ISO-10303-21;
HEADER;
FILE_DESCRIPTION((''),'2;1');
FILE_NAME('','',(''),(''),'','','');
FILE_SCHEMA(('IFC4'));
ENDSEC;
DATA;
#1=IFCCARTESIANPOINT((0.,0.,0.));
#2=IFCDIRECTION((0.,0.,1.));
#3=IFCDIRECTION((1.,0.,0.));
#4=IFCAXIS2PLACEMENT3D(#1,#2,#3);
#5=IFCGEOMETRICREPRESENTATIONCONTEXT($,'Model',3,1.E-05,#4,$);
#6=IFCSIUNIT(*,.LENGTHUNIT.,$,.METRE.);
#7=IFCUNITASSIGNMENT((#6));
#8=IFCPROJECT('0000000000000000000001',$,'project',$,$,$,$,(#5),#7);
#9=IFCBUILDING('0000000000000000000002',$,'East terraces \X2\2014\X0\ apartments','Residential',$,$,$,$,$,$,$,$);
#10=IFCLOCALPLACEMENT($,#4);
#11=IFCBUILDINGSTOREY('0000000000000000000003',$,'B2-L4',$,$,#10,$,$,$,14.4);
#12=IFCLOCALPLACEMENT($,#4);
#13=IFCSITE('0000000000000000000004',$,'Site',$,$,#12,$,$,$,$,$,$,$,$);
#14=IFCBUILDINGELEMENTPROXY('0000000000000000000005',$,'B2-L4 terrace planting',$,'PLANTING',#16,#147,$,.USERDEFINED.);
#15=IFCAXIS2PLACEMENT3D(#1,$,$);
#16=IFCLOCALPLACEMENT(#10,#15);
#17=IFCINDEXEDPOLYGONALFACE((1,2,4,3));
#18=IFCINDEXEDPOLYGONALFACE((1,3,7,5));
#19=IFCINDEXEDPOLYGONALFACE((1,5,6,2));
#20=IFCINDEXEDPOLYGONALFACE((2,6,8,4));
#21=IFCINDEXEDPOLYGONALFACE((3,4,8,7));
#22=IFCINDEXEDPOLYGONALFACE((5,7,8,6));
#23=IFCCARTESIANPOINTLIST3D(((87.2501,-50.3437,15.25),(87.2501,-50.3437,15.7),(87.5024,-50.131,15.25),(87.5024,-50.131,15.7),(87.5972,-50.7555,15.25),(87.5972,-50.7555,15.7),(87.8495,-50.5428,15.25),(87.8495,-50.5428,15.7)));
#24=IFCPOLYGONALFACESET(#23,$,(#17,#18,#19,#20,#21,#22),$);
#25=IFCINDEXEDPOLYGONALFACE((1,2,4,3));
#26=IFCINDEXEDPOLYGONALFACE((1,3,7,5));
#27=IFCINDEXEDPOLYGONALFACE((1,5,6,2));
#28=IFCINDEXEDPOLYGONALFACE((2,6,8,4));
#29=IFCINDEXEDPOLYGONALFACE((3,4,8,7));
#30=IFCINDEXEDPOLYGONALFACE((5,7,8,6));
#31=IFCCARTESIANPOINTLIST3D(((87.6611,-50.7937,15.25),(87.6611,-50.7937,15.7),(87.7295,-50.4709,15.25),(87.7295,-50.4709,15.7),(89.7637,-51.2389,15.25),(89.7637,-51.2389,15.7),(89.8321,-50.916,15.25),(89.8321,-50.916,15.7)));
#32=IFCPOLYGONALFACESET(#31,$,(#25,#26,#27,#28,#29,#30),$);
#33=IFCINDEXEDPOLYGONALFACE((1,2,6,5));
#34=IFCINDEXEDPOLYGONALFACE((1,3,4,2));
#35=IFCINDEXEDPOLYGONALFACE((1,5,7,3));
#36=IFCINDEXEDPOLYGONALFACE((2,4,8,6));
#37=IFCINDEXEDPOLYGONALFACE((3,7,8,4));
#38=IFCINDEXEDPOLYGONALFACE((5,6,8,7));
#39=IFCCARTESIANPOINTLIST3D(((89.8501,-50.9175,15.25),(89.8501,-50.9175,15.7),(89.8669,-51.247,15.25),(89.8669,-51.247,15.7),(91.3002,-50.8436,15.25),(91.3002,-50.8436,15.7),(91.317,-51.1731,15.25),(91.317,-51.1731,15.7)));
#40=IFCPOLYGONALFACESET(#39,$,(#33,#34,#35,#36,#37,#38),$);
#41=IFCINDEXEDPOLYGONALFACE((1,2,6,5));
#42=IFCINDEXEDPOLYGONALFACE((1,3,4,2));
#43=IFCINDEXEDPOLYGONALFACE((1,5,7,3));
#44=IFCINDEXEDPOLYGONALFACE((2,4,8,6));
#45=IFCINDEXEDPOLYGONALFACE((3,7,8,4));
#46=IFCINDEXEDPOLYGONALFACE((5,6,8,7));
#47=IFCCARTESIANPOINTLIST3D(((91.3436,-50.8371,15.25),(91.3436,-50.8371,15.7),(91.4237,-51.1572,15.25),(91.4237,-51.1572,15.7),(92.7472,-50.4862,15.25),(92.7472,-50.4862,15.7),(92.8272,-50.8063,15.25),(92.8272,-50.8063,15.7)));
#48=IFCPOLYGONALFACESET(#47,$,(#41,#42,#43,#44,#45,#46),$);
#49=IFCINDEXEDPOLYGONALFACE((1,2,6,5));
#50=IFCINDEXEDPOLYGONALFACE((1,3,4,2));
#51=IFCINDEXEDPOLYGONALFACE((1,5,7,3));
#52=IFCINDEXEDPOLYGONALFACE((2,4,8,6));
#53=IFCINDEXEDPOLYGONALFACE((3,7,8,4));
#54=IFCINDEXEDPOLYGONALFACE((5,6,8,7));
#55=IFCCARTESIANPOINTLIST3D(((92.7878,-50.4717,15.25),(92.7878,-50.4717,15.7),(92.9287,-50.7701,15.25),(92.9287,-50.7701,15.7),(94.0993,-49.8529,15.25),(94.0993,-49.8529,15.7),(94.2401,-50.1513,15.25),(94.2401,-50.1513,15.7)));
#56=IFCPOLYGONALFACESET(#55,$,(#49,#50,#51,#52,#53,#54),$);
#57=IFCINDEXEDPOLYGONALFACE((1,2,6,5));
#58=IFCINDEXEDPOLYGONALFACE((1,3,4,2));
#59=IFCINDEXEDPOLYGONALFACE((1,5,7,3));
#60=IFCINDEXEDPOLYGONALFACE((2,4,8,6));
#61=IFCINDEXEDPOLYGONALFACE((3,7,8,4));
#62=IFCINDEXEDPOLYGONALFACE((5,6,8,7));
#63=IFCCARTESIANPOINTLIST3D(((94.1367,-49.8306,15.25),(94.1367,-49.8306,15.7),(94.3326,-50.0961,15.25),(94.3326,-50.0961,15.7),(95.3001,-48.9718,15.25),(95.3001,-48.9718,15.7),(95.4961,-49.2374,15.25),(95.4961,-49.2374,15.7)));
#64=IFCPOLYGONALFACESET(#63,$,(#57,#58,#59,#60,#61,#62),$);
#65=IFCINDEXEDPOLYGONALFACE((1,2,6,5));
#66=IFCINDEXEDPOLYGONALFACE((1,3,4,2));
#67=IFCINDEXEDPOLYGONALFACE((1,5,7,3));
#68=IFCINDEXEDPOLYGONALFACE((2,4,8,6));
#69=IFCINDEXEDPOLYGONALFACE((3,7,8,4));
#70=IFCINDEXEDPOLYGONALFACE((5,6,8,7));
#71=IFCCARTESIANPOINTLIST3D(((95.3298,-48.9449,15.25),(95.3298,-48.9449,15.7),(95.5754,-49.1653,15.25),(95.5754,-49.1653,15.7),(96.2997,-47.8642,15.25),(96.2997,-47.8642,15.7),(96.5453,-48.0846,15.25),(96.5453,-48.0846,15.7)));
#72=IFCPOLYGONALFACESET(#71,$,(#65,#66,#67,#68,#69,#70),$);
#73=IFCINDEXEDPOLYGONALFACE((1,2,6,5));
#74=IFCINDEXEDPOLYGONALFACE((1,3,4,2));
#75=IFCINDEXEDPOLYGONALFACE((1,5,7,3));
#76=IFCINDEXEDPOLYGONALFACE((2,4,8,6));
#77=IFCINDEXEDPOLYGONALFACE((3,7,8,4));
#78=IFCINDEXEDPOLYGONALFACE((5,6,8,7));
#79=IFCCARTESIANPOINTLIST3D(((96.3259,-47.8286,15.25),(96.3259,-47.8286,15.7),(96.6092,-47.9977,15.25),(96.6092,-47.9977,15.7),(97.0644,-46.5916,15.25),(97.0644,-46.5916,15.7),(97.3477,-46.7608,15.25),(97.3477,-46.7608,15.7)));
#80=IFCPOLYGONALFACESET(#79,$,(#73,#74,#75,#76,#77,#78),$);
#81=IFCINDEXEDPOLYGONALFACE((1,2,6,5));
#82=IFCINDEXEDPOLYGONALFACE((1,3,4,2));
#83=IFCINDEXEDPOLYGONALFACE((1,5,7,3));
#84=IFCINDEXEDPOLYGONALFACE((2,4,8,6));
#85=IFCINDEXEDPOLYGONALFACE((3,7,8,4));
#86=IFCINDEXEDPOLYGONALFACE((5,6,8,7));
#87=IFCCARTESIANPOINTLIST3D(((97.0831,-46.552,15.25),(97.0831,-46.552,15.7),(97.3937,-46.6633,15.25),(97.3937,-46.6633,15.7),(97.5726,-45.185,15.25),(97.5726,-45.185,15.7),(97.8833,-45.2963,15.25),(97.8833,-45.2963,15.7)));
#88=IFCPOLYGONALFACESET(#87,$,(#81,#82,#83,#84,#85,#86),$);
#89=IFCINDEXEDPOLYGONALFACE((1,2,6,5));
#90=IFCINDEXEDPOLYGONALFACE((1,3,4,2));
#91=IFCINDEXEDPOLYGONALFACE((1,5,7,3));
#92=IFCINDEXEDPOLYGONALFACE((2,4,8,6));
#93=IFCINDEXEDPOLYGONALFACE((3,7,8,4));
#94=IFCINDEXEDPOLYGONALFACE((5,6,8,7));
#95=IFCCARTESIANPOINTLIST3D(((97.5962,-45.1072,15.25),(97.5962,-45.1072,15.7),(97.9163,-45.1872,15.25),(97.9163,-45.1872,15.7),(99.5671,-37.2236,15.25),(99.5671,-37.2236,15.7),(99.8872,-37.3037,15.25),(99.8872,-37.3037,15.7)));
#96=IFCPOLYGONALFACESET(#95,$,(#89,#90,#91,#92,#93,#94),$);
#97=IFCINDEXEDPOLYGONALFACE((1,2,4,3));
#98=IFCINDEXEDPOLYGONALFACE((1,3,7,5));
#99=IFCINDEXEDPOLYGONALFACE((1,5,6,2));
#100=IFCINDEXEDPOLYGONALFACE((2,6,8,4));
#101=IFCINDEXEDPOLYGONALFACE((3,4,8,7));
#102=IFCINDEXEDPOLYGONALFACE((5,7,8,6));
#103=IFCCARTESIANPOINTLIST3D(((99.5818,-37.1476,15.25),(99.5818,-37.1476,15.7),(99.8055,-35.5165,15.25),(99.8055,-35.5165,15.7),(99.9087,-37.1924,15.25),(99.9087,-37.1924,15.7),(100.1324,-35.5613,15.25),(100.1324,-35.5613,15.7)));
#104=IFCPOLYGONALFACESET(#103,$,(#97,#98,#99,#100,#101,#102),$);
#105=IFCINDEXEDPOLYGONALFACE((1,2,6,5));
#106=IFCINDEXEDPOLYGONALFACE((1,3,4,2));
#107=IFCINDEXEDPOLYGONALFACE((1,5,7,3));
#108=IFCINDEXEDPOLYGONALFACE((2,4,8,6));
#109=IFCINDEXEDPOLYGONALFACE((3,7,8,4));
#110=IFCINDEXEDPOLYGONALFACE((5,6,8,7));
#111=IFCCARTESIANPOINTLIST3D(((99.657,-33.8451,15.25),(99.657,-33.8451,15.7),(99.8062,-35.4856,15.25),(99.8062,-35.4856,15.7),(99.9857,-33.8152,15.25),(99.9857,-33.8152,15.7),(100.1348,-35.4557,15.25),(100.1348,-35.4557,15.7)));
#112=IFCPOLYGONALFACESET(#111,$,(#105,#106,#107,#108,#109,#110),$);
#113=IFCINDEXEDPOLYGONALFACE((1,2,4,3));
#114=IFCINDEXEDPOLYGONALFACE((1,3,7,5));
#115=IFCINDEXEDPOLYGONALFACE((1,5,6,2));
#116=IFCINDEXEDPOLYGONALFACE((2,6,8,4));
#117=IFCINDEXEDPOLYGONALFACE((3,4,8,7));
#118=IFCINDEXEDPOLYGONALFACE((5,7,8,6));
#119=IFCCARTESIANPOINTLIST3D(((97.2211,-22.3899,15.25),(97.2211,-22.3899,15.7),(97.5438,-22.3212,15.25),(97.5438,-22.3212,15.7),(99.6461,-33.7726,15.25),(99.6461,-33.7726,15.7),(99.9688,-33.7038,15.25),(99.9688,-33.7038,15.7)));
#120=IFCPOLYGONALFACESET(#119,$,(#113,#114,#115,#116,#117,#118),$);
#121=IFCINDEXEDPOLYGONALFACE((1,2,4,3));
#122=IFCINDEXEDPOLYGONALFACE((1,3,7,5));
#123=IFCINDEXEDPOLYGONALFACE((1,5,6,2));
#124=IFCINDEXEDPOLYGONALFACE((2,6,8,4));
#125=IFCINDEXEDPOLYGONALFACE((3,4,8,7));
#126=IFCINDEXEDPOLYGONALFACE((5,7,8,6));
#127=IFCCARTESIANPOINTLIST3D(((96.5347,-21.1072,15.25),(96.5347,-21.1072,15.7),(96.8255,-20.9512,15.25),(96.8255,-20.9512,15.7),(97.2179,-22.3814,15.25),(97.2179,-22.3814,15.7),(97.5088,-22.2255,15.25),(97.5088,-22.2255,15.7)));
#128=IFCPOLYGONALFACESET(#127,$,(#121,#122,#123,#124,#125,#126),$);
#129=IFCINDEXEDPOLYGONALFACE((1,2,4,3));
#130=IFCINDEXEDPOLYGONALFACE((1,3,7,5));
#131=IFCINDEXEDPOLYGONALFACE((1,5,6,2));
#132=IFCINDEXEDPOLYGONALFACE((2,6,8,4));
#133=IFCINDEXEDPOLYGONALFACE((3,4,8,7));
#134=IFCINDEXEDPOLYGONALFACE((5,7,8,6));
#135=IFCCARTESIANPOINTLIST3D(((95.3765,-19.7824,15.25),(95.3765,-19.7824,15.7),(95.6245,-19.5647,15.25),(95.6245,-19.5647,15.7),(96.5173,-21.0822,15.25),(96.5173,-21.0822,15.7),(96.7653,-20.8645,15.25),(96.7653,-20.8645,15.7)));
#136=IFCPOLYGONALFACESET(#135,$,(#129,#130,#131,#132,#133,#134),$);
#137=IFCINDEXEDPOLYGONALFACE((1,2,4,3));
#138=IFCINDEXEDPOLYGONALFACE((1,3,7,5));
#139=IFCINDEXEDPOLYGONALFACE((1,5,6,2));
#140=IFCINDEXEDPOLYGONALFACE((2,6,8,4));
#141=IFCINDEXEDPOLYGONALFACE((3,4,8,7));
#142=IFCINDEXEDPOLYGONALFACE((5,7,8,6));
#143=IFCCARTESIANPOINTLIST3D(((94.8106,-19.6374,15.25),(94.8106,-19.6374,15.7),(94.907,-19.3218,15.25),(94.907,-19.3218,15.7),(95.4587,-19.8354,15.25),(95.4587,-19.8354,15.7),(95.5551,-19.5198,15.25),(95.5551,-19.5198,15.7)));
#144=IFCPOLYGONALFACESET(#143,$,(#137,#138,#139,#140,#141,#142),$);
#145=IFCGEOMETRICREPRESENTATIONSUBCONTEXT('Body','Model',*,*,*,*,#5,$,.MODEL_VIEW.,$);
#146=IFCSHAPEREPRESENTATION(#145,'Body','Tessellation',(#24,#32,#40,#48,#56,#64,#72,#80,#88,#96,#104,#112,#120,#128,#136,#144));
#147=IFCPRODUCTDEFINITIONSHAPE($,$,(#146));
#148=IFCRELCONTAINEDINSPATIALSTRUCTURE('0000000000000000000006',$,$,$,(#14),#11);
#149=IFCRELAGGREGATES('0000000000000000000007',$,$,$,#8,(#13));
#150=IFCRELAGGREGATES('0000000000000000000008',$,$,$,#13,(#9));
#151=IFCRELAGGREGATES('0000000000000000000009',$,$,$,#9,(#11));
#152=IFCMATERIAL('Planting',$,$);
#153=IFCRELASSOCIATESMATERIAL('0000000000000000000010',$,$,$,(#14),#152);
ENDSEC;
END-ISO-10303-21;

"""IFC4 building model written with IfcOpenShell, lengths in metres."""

from ifc_helpers import new_model, si_unit, frame, origin_with_axes, place, context, subcontext, project, spatial, polyline, outline, extrude, material, element, save


model = new_model("IFC4")

# Units and contexts
model_context = context("Model", 3, precision=1e-05, world=origin_with_axes())
body_context = subcontext(model_context, "Body", "Model", "MODEL_VIEW")
ifc_project = project(units=[si_unit("LENGTHUNIT", "METRE")], contexts=[model_context])

# Site, building, storey
site_placement = place(None, origin_with_axes())
site = spatial("IfcSite", under=ifc_project, at=site_placement, Name="Site")
building = spatial("IfcBuilding", under=site, Name="East terraces — apartments", Description="Residential")
storey_placement = place(None, origin_with_axes())
storey = spatial("IfcBuildingStorey", under=building, at=storey_placement, Name="B2-L4", Elevation=14.4)

# Building element proxy
ifc_material_1 = material(Name="Planting")
proxy_1_placement = place(storey_placement, origin_with_axes())
element("IfcBuildingElementProxy", 1, at=proxy_1_placement, inside=storey, material=ifc_material_1, Name="B2-L4 terrace planting", ObjectType="PLANTING", PredefinedType="USERDEFINED", context=body_context, shape_type="SweptSolid", body=[
    extrude(outline(polyline([(87.2501, -50.3437), (87.5972, -50.7555), (87.8495, -50.5428), (87.5024, -50.131), (87.2501, -50.3437)])), frame((0.0, 0.0, 15.25), z_axis=(0.0, 0.0, 1.0), x_axis=(1.0, 0.0, 0.0)), (0.0, 0.0, 1.0), 0.45),
    extrude(outline(polyline([(87.6611, -50.7937), (89.7637, -51.2389), (89.8321, -50.916), (87.7295, -50.4709), (87.6611, -50.7937)])), frame((0.0, 0.0, 15.25), z_axis=(0.0, 0.0, 1.0), x_axis=(1.0, 0.0, 0.0)), (0.0, 0.0, 1.0), 0.45),
    extrude(outline(polyline([(89.8669, -51.247), (91.317, -51.1731), (91.3002, -50.8436), (89.8501, -50.9175), (89.8669, -51.247)])), frame((0.0, 0.0, 15.25), z_axis=(0.0, 0.0, 1.0), x_axis=(1.0, 0.0, 0.0)), (0.0, 0.0, 1.0), 0.45),
    extrude(outline(polyline([(91.4237, -51.1572), (92.8272, -50.8063), (92.7472, -50.4862), (91.3436, -50.8371), (91.4237, -51.1572)])), frame((0.0, 0.0, 15.25), z_axis=(0.0, 0.0, 1.0), x_axis=(1.0, 0.0, 0.0)), (0.0, 0.0, 1.0), 0.45),
    extrude(outline(polyline([(92.9287, -50.7701), (94.2401, -50.1513), (94.0993, -49.8529), (92.7878, -50.4717), (92.9287, -50.7701)])), frame((0.0, 0.0, 15.25), z_axis=(0.0, 0.0, 1.0), x_axis=(1.0, 0.0, 0.0)), (0.0, 0.0, 1.0), 0.45),
    extrude(outline(polyline([(94.3326, -50.0961), (95.4961, -49.2374), (95.3001, -48.9718), (94.1367, -49.8306), (94.3326, -50.0961)])), frame((0.0, 0.0, 15.25), z_axis=(0.0, 0.0, 1.0), x_axis=(1.0, 0.0, 0.0)), (0.0, 0.0, 1.0), 0.45),
    extrude(outline(polyline([(95.5754, -49.1653), (96.5453, -48.0846), (96.2997, -47.8642), (95.3298, -48.9449), (95.5754, -49.1653)])), frame((0.0, 0.0, 15.25), z_axis=(0.0, 0.0, 1.0), x_axis=(1.0, 0.0, 0.0)), (0.0, 0.0, 1.0), 0.45),
    extrude(outline(polyline([(96.6092, -47.9977), (97.3477, -46.7608), (97.0644, -46.5916), (96.3259, -47.8286), (96.6092, -47.9977)])), frame((0.0, 0.0, 15.25), z_axis=(0.0, 0.0, 1.0), x_axis=(1.0, 0.0, 0.0)), (0.0, 0.0, 1.0), 0.45),
    extrude(outline(polyline([(97.3937, -46.6633), (97.8833, -45.2963), (97.5726, -45.185), (97.0831, -46.552), (97.3937, -46.6633)])), frame((0.0, 0.0, 15.25), z_axis=(0.0, 0.0, 1.0), x_axis=(1.0, 0.0, 0.0)), (0.0, 0.0, 1.0), 0.45),
    extrude(outline(polyline([(97.9163, -45.1872), (99.8872, -37.3037), (99.5671, -37.2236), (97.5962, -45.1072), (97.9163, -45.1872)])), frame((0.0, 0.0, 15.25), z_axis=(0.0, 0.0, 1.0), x_axis=(1.0, 0.0, 0.0)), (0.0, 0.0, 1.0), 0.45),
    extrude(outline(polyline([(99.9087, -37.1924), (100.1324, -35.5613), (99.8055, -35.5165), (99.5818, -37.1476), (99.9087, -37.1924)])), frame((0.0, 0.0, 15.25), z_axis=(0.0, 0.0, 1.0), x_axis=(1.0, 0.0, 0.0)), (0.0, 0.0, 1.0), 0.45),
    extrude(outline(polyline([(100.1348, -35.4557), (99.9857, -33.8152), (99.657, -33.8451), (99.8062, -35.4856), (100.1348, -35.4557)])), frame((0.0, 0.0, 15.25), z_axis=(0.0, 0.0, 1.0), x_axis=(1.0, 0.0, 0.0)), (0.0, 0.0, 1.0), 0.45),
    extrude(outline(polyline([(99.9688, -33.7038), (97.5438, -22.3212), (97.2211, -22.3899), (99.6461, -33.7726), (99.9688, -33.7038)])), frame((0.0, 0.0, 15.25), z_axis=(0.0, 0.0, 1.0), x_axis=(1.0, 0.0, 0.0)), (0.0, 0.0, 1.0), 0.45),
    extrude(outline(polyline([(97.5088, -22.2255), (96.8255, -20.9512), (96.5347, -21.1072), (97.2179, -22.3814), (97.5088, -22.2255)])), frame((0.0, 0.0, 15.25), z_axis=(0.0, 0.0, 1.0), x_axis=(1.0, 0.0, 0.0)), (0.0, 0.0, 1.0), 0.45),
    extrude(outline(polyline([(96.7653, -20.8645), (95.6245, -19.5647), (95.3765, -19.7824), (96.5173, -21.0822), (96.7653, -20.8645)])), frame((0.0, 0.0, 15.25), z_axis=(0.0, 0.0, 1.0), x_axis=(1.0, 0.0, 0.0)), (0.0, 0.0, 1.0), 0.45),
    extrude(outline(polyline([(95.5551, -19.5198), (94.907, -19.3218), (94.8106, -19.6374), (95.4587, -19.8354), (95.5551, -19.5198)])), frame((0.0, 0.0, 15.25), z_axis=(0.0, 0.0, 1.0), x_axis=(1.0, 0.0, 0.0)), (0.0, 0.0, 1.0), 0.45),
])

save(model, "model.ifc")
